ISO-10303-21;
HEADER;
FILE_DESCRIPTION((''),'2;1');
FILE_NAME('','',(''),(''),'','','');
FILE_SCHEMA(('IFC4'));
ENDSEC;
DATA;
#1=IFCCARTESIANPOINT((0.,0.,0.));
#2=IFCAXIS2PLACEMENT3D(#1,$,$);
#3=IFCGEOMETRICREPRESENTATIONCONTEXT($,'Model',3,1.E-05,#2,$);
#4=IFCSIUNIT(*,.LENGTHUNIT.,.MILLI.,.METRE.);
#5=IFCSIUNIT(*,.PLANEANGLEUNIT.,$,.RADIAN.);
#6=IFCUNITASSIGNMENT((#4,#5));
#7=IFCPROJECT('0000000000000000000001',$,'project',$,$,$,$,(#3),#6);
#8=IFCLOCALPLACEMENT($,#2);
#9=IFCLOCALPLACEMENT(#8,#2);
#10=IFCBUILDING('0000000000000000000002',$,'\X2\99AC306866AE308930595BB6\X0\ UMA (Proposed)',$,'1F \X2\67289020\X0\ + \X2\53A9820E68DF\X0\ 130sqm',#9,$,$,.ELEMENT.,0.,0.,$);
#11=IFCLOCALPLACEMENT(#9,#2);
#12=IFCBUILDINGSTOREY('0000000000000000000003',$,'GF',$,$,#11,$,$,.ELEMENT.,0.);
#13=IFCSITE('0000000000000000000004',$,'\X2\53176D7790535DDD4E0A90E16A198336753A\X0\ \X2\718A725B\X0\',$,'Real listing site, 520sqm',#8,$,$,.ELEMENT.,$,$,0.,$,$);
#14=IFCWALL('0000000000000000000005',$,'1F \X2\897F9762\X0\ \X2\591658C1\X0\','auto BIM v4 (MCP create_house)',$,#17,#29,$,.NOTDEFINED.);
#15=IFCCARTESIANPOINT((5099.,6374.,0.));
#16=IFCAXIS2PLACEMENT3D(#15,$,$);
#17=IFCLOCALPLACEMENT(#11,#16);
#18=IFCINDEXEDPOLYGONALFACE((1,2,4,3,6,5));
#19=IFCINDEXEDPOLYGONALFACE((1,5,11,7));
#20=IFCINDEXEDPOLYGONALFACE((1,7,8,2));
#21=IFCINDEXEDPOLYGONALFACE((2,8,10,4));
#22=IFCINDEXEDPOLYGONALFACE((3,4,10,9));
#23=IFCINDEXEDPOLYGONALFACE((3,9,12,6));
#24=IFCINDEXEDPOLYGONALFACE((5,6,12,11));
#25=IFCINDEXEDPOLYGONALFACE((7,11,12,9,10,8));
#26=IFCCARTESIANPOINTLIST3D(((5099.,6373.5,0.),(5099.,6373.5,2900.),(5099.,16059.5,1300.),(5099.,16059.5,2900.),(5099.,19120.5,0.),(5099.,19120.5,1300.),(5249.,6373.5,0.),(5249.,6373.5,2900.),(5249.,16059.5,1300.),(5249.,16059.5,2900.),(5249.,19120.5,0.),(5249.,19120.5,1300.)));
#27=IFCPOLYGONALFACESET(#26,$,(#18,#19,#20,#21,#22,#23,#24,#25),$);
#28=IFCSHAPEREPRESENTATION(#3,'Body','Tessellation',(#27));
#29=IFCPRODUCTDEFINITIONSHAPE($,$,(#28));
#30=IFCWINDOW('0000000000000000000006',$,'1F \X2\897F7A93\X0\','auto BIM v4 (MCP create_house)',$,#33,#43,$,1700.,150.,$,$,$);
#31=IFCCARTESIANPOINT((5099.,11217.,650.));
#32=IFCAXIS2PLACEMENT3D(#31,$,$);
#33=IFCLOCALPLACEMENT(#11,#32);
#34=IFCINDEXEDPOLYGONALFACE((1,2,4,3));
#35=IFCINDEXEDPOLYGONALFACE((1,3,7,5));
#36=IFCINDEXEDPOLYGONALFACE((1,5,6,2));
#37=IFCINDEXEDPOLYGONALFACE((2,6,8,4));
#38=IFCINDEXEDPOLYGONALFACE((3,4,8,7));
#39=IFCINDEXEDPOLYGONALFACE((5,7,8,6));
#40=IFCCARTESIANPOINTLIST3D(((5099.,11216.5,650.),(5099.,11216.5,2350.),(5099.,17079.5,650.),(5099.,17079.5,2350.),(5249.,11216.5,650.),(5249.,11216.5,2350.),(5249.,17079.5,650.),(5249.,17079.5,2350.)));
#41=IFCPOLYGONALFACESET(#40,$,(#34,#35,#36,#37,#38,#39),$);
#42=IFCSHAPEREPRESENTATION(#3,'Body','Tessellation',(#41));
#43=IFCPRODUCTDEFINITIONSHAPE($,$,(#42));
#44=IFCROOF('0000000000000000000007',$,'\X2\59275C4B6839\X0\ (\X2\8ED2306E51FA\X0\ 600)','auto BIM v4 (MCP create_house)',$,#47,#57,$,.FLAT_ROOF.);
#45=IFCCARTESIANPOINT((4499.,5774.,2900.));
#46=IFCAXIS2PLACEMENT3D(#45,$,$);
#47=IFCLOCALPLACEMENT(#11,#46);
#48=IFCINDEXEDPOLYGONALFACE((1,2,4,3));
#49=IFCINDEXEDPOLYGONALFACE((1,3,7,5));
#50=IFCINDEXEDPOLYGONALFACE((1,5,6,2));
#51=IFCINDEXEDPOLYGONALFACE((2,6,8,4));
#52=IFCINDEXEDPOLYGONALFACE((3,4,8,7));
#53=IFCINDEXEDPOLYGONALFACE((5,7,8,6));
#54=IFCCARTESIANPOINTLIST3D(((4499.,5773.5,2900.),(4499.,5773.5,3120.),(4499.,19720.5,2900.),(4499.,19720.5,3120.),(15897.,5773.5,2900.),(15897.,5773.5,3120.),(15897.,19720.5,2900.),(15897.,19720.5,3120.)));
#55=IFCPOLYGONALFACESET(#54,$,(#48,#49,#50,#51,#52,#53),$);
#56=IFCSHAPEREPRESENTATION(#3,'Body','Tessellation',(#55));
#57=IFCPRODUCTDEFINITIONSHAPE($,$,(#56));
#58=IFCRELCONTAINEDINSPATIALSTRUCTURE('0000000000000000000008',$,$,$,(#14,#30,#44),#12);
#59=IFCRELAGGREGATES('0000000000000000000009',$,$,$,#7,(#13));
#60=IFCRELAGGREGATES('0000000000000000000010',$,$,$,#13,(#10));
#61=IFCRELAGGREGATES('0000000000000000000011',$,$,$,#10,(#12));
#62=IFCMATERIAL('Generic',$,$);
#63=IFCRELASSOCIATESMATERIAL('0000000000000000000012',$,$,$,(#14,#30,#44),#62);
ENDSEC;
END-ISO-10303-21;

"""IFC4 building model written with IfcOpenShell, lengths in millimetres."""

from ifc_helpers import new_model, si_unit, frame, frame_2d, origin, place, context, project, spatial, rectangle, extrude, material, element, fill, save


model = new_model("IFC4")

# Units and contexts
model_context = context("Model", 3, precision=1e-05, world=origin())
ifc_project = project(units=[si_unit("LENGTHUNIT", "METRE", prefix="MILLI"), si_unit("PLANEANGLEUNIT", "RADIAN")], contexts=[model_context])

# Site, building, storey
site_placement = place(None, origin())
site = spatial("IfcSite", under=ifc_project, at=site_placement, Name="北海道川上郡標茶町 熊牛", ObjectType="Real listing site, 520sqm", CompositionType="ELEMENT", RefElevation=0.0)
building_placement = place(site_placement, origin())
building = spatial("IfcBuilding", under=site, at=building_placement, Name="馬と暮らす家 UMA (Proposed)", ObjectType="1F 木造 + 厩舎棟 130sqm", CompositionType="ELEMENT", ElevationOfRefHeight=0.0, ElevationOfTerrain=0.0)
storey_placement = place(building_placement, origin())
storey = spatial("IfcBuildingStorey", under=building, at=storey_placement, Name="GF", CompositionType="ELEMENT", Elevation=0.0)

# Shared definitions
ifc_material = material(Name="Generic")

# Wall, opening, window
wall_1_placement = place(storey_placement, frame((5099.0, 6374.0, 0.0)))
wall_1 = element("IfcWall", 1, at=wall_1_placement, inside=storey, material=ifc_material, Name="1F 西面 外壁", Description="auto BIM v4 (MCP create_house)", PredefinedType="NOTDEFINED", context=model_context, shape_type="SweptSolid", body=[
    extrude(rectangle(XDim=150.0, YDim=12747.0, at=frame_2d((75.0, 6373.0))), frame((5099.0, 6374.0, 0.0)), (0.0, 0.0, 1.0), 2900.0),
])
opening_1_placement = place(storey_placement, frame((5099.0, 11217.0, 650.0)))
opening_1 = element("IfcOpeningElement", 2, at=opening_1_placement, cuts=wall_1, PredefinedType="NOTDEFINED", context=model_context, shape_type="SweptSolid", body=[
    extrude(rectangle(XDim=150.0, YDim=5863.0, at=frame_2d((75.0, 2931.0))), frame((5099.0, 11217.0, 650.0)), (0.0, 0.0, 1.0), 1700.0),
])
window_1_placement = place(storey_placement, frame((5099.0, 11217.0, 650.0)))
window_1 = element("IfcWindow", 3, at=window_1_placement, inside=storey, material=ifc_material, Name="1F 西窓", Description="auto BIM v4 (MCP create_house)", OverallHeight=1700.0, OverallWidth=150.0, context=model_context, shape_type="SweptSolid", body=[
    extrude(rectangle(XDim=150.0, YDim=5863.0, at=frame_2d((75.0, 2931.0))), frame((5099.0, 11217.0, 650.0)), (0.0, 0.0, 1.0), 1700.0),
])
fill(opening_1, window_1)

# Roof
roof_placement = place(storey_placement, frame((4499.0, 5774.0, 2900.0)))
element("IfcRoof", 4, at=roof_placement, inside=storey, material=ifc_material, Name="大屋根 (軒の出 600)", Description="auto BIM v4 (MCP create_house)", PredefinedType="FLAT_ROOF", context=model_context, shape_type="SweptSolid", body=[
    extrude(rectangle(XDim=11398.0, YDim=13947.0, at=frame_2d((5699.0, 6973.0))), frame((4499.0, 5774.0, 2900.0)), (0.0, 0.0, 1.0), 220.0),
])

save(model, "model.ifc")
